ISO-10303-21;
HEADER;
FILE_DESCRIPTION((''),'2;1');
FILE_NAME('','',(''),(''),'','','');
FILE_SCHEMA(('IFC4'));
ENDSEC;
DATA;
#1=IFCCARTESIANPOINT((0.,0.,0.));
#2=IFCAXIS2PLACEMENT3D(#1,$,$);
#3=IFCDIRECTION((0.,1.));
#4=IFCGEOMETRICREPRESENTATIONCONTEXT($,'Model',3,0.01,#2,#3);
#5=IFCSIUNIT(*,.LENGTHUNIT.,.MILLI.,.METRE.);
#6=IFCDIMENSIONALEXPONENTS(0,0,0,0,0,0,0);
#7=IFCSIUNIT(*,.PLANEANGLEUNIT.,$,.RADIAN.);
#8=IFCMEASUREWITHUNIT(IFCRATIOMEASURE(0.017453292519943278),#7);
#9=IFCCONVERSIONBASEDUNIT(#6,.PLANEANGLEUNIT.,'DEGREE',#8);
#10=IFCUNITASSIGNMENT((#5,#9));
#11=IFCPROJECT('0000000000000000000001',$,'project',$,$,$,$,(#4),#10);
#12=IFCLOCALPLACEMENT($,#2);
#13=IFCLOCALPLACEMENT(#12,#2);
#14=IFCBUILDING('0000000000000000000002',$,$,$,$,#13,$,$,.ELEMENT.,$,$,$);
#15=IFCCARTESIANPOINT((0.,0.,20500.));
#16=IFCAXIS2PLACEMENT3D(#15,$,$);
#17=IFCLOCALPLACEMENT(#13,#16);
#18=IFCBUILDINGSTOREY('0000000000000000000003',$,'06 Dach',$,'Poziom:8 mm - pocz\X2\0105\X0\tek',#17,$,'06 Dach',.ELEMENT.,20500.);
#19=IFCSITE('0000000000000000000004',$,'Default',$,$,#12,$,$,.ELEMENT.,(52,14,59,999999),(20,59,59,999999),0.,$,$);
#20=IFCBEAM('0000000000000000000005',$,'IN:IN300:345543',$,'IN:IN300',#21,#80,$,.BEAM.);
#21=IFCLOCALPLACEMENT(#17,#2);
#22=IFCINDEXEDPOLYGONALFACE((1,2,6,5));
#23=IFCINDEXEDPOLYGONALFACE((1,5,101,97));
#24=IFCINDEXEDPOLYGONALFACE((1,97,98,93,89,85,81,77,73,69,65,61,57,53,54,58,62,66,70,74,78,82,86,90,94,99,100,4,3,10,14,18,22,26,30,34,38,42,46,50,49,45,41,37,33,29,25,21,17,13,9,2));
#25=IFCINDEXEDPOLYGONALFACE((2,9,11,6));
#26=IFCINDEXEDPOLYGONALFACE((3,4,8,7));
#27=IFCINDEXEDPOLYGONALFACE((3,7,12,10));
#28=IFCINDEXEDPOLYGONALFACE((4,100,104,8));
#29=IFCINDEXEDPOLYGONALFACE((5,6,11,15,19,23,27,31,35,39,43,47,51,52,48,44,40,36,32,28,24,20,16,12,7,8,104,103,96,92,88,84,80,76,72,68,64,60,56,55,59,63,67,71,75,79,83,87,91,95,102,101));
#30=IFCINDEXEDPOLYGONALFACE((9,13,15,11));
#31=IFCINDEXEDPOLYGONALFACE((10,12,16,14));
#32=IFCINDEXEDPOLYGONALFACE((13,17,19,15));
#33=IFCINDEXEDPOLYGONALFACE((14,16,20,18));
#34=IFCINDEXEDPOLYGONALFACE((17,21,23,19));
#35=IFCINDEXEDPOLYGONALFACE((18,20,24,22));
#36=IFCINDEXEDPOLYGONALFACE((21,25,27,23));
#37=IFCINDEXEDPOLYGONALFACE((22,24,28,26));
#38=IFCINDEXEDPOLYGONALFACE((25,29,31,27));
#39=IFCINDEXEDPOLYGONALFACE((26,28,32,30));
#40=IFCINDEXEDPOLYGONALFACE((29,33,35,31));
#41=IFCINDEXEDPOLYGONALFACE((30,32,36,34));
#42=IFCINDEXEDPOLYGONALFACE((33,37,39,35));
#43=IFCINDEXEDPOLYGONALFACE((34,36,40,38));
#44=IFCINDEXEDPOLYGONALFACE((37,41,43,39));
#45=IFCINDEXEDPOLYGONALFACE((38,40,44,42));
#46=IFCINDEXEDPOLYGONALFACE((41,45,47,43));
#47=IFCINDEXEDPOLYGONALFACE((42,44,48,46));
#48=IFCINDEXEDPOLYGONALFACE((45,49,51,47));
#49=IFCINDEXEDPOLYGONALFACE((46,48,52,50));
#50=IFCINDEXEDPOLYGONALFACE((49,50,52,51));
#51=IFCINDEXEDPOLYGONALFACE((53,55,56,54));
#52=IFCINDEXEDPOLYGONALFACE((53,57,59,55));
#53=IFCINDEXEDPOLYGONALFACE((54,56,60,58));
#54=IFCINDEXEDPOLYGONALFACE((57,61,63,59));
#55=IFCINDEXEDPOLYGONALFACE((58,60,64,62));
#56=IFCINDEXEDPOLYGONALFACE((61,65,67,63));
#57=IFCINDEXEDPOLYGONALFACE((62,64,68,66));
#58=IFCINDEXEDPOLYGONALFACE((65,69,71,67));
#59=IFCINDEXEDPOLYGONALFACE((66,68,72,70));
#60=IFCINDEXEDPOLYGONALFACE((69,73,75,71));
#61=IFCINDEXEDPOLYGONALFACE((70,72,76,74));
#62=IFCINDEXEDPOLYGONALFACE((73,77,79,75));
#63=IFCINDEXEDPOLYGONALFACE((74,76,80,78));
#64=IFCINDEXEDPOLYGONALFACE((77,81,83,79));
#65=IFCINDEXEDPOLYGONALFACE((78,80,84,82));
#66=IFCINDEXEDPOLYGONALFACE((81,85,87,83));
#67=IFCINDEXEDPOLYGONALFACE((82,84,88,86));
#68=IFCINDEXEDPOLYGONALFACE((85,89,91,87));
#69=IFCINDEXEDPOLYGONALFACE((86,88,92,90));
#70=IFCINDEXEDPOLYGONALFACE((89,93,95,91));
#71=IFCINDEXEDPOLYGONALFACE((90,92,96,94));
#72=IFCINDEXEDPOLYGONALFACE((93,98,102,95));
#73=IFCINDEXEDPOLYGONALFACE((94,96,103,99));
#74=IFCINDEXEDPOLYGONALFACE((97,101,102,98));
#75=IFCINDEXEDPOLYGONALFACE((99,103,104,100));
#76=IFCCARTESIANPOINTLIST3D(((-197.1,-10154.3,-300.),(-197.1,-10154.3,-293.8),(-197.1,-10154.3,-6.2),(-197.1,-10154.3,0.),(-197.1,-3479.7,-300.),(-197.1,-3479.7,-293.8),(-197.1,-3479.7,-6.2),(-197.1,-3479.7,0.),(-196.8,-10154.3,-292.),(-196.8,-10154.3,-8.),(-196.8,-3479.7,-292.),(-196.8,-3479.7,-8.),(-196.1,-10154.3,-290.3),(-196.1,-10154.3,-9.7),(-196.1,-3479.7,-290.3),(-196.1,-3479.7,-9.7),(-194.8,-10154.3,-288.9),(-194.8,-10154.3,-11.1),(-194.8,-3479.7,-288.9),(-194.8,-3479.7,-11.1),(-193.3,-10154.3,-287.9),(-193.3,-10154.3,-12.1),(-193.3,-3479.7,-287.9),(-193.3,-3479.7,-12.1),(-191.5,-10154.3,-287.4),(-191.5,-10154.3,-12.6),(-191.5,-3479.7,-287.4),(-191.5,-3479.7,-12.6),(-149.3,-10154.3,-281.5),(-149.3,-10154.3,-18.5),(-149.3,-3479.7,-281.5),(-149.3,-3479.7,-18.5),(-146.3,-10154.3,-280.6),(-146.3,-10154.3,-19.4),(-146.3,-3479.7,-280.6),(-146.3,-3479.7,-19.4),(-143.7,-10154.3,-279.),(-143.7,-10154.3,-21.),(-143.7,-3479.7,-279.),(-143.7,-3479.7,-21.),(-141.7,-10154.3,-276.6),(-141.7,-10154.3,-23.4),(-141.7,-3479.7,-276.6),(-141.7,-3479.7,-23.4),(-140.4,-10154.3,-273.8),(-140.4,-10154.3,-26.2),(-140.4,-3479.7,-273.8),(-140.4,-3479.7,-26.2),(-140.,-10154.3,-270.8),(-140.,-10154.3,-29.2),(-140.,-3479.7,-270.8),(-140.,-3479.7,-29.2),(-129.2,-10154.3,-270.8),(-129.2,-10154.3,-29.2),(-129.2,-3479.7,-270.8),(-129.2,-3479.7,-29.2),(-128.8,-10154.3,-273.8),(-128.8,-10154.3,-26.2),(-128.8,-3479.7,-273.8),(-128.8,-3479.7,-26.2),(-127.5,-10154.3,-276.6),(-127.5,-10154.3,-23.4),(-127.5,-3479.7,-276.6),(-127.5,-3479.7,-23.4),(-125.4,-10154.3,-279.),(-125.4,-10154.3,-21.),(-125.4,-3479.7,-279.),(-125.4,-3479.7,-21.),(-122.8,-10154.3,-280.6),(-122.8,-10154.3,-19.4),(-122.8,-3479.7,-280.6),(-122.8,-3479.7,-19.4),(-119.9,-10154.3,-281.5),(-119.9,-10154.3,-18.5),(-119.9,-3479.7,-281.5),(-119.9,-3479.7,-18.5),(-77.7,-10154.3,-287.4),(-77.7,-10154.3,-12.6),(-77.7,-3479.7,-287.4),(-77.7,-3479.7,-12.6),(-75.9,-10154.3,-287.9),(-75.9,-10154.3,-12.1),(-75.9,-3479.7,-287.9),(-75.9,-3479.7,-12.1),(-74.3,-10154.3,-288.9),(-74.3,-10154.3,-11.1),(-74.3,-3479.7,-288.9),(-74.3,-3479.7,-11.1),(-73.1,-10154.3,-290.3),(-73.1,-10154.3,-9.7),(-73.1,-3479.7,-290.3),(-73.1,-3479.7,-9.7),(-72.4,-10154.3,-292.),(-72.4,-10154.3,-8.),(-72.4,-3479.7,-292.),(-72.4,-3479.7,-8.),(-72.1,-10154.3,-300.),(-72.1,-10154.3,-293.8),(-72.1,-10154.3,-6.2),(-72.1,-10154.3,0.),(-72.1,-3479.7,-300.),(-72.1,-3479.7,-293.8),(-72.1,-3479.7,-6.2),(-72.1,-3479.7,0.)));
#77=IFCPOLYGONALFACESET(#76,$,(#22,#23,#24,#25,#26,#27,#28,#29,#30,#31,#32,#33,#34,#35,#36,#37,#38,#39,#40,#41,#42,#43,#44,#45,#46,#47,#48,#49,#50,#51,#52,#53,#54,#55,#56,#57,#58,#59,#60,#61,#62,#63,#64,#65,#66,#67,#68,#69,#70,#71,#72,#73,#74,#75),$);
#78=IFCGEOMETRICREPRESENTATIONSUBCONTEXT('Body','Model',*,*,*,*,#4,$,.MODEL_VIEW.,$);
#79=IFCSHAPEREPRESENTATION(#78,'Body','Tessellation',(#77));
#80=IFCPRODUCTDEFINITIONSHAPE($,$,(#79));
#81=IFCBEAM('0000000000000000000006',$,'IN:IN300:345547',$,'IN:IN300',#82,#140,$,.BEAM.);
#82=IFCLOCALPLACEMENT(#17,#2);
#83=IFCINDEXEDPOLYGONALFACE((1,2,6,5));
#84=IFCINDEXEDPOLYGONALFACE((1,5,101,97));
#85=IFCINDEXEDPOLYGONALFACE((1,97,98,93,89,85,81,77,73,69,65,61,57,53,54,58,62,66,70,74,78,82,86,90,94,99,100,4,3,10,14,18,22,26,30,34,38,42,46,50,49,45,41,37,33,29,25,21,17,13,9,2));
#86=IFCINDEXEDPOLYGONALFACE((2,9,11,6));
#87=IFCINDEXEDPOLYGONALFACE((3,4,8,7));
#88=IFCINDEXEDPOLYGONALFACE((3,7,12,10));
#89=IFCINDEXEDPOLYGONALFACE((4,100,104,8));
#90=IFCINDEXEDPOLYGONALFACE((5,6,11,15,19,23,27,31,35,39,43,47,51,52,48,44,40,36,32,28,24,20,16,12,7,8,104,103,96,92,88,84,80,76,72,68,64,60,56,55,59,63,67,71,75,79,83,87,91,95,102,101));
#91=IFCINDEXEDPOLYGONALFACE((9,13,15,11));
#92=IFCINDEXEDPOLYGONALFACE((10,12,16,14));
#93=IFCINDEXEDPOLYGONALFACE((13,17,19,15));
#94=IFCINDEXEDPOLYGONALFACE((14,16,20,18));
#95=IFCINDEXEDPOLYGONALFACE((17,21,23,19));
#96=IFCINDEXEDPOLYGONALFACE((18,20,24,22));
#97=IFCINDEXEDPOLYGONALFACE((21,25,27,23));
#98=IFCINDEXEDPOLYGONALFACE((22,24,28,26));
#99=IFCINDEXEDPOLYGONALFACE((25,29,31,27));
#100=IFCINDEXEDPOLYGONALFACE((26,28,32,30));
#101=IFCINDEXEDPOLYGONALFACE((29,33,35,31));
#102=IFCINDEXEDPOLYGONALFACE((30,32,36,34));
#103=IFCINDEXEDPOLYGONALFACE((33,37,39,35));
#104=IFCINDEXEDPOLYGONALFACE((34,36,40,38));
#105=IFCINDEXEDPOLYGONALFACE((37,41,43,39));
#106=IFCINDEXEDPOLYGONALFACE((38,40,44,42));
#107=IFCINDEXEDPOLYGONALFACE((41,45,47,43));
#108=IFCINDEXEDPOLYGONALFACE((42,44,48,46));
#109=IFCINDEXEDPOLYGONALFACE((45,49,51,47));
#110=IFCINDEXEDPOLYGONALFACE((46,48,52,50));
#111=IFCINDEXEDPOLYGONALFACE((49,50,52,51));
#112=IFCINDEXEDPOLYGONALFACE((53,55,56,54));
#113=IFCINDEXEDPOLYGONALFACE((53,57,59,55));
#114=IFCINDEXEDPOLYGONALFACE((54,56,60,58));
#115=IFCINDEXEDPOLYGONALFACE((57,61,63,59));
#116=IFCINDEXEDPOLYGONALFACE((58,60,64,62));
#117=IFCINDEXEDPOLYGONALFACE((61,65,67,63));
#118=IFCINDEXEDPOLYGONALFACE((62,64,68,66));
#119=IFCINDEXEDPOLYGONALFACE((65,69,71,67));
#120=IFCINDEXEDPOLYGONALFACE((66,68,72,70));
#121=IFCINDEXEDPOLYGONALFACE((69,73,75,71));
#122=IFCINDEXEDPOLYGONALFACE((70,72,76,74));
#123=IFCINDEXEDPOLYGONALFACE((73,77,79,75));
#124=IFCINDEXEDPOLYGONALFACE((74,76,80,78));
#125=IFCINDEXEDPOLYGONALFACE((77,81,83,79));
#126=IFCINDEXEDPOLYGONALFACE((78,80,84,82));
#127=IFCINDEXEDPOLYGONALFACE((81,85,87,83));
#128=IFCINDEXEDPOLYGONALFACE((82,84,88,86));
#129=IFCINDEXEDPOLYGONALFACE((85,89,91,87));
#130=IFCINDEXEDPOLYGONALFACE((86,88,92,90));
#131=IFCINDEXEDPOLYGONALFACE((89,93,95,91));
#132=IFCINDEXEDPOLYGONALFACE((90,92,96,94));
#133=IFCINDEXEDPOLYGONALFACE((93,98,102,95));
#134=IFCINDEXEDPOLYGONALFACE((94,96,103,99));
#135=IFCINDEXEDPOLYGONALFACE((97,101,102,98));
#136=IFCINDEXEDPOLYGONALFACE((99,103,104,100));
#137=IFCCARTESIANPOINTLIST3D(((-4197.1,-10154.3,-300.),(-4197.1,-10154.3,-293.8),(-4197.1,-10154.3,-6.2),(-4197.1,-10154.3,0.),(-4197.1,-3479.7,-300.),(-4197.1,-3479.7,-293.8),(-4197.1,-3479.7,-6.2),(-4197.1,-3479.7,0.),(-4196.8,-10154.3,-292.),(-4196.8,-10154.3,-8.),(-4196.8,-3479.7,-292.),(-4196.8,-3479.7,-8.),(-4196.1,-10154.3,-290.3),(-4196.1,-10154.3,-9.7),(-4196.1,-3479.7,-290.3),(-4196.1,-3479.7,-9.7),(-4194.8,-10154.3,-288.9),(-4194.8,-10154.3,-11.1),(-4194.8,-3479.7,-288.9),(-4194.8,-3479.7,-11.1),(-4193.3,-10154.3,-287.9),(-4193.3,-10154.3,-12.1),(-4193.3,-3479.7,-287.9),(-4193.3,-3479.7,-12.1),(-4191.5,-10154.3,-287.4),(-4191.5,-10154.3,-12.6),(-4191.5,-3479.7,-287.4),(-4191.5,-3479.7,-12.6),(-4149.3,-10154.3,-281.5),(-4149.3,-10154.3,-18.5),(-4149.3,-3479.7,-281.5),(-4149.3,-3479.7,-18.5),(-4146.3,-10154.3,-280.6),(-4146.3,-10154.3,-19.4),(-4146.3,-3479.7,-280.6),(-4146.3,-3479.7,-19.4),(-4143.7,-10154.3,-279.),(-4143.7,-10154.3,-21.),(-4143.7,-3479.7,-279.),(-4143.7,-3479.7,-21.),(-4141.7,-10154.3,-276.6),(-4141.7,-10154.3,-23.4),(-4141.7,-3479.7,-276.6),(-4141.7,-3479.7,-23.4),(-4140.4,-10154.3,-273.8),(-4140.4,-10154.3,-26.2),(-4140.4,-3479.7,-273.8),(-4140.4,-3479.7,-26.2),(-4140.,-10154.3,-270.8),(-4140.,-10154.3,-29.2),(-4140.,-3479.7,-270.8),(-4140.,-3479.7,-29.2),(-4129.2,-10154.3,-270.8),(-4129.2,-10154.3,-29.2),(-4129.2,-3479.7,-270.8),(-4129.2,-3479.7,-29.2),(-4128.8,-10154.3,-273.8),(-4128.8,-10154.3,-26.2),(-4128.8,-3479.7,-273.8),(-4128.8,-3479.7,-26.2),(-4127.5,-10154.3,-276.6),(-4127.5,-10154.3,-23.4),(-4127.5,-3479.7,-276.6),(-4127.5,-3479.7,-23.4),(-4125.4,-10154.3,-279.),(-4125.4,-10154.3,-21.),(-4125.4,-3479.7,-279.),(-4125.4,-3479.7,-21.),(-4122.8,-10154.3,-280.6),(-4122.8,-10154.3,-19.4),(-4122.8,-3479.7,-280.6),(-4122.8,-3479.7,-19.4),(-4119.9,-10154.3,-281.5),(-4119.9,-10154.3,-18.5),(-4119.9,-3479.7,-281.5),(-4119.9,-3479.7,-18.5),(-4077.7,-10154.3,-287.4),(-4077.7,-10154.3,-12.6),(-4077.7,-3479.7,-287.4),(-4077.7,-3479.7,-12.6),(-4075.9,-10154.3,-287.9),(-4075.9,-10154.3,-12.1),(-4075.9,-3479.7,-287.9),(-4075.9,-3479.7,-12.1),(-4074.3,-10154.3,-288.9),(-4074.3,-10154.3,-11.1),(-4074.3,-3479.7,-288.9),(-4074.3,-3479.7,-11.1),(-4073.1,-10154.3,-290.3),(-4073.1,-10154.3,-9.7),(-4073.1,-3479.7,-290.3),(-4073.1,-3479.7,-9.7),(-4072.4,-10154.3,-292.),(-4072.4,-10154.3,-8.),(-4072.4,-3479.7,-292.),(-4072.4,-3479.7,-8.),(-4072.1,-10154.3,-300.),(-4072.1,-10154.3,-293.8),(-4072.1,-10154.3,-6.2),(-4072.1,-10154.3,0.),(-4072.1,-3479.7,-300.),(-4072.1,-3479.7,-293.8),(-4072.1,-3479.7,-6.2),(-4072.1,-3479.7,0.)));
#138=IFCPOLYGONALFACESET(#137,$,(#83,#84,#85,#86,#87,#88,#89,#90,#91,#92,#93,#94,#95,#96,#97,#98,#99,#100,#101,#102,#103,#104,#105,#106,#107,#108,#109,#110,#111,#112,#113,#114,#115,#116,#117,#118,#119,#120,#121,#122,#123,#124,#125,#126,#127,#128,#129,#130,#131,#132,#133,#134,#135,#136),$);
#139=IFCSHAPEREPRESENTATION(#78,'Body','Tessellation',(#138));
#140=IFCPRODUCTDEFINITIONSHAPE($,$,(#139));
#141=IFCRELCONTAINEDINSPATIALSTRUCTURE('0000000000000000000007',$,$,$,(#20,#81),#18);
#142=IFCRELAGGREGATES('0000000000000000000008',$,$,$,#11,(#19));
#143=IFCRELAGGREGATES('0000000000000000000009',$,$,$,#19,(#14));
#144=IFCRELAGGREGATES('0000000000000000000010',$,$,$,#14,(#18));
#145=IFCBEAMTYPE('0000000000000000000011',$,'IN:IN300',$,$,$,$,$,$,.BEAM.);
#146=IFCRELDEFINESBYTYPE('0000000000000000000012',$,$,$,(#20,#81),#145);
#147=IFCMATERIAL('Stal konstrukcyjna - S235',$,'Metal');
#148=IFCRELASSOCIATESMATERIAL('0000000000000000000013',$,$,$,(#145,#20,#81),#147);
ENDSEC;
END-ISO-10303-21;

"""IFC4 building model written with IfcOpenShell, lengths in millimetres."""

from ifc_helpers import new_model, entity, si_unit, converted_unit, direction, frame, origin, place, context, subcontext, project, spatial, line, arc, indexed_curve, outline, extrude, source, transform, mapped, material, type_object, type_shapes, element, save


model = new_model("IFC4")

# Units and contexts
model_context = context("Model", 3, precision=0.01, world=origin(), true_north=direction((0.0, 1.0)))
body_context = subcontext(model_context, "Body", "Model", "MODEL_VIEW")
ifc_project = project(units=[si_unit("LENGTHUNIT", "METRE", prefix="MILLI"), converted_unit("PLANEANGLEUNIT", "DEGREE", entity("IfcRatioMeasure", 0.017453292519943278), si_unit("PLANEANGLEUNIT", "RADIAN"), dimensions=[0, 0, 0, 0, 0, 0, 0])], contexts=[model_context])

# Site, building, storey
site_placement = place(None, origin())
site = spatial("IfcSite", under=ifc_project, at=site_placement, Name="Default", CompositionType="ELEMENT", RefLatitude=(52, 14, 59, 999999), RefLongitude=(20, 59, 59, 999999), RefElevation=0.0)
building_placement = place(site_placement, origin())
building = spatial("IfcBuilding", under=site, at=building_placement, CompositionType="ELEMENT")
storey_placement = place(building_placement, frame((0.0, 0.0, 20500.0)))
storey = spatial("IfcBuildingStorey", under=building, at=storey_placement, Name="06 Dach", ObjectType="Poziom:8 mm - początek", LongName="06 Dach", CompositionType="ELEMENT", Elevation=20500.0)

# Beams
ifc_material_1 = material(Name="Stal konstrukcyjna - S235", Category="Metal")
beam_type_1 = type_object("IfcBeamType", Name="IN:IN300", PredefinedType="BEAM", material=ifc_material_1)
shared_shape_1 = source(origin(), body_context, "Body", "SweptSolid", [
    extrude(outline(indexed_curve([(143.8, -62.5), (150.0, -62.5), (150.0, 62.5), (143.8, 62.5), (139.6, 60.9), (137.4, 56.9), (131.5, 14.7), (127.9, 8.1), (120.8, 5.4), (-120.8, 5.4), (-127.9, 8.1), (-131.5, 14.7), (-137.4, 56.9), (-139.6, 60.9), (-143.8, 62.5), (-150.0, 62.5), (-150.0, -62.5), (-143.8, -62.5), (-139.6, -60.9), (-137.4, -56.9), (-131.5, -14.7), (-127.9, -8.1), (-120.8, -5.4), (120.8, -5.4), (127.9, -8.1), (131.5, -14.7), (137.4, -56.9), (139.6, -60.9)], segments=[line(1, 2, 3, 4), arc(4, 5, 6), line(6, 7), arc(7, 8, 9), line(9, 10), arc(10, 11, 12), line(12, 13), arc(13, 14, 15), line(15, 16, 17, 18), arc(18, 19, 20), line(20, 21), arc(21, 22, 23), line(23, 24), arc(24, 25, 26), line(26, 27), arc(27, 28, 1)], self_intersect=False)), frame((-3337.3, 0.0, 0.0), z_axis=(1.0, 0.0, 0.0), x_axis=(0.0, 0.0, -1.0)), (0.0, 0.0, 1.0), 6674.6),
])
type_shapes(beam_type_1, [shared_shape_1])
for number, where, z_axis, x_axis, name in (
    (1, (-134.6, -6817.0, -150.0), (0.0, 0.0, 1.0), (0.0, -1.0, 0.0), "IN:IN300:345543"),
    (2, (-4134.6, -6817.0, -150.0), (0.0, 0.0, 1.0), (0.0, -1.0, 0.0), "IN:IN300:345547"),
):
    element("IfcBeam", number, at=place(storey_placement, frame(where, z_axis=z_axis, x_axis=x_axis)), inside=storey, type_object=beam_type_1, material=ifc_material_1, Name=name, ObjectType="IN:IN300", PredefinedType="BEAM", context=body_context, shape_type="MappedRepresentation", body=[
        mapped(shared_shape_1, transform((0.0, 0.0, 0.0), scale=1.0)),
    ])

save(model, "model.ifc")
